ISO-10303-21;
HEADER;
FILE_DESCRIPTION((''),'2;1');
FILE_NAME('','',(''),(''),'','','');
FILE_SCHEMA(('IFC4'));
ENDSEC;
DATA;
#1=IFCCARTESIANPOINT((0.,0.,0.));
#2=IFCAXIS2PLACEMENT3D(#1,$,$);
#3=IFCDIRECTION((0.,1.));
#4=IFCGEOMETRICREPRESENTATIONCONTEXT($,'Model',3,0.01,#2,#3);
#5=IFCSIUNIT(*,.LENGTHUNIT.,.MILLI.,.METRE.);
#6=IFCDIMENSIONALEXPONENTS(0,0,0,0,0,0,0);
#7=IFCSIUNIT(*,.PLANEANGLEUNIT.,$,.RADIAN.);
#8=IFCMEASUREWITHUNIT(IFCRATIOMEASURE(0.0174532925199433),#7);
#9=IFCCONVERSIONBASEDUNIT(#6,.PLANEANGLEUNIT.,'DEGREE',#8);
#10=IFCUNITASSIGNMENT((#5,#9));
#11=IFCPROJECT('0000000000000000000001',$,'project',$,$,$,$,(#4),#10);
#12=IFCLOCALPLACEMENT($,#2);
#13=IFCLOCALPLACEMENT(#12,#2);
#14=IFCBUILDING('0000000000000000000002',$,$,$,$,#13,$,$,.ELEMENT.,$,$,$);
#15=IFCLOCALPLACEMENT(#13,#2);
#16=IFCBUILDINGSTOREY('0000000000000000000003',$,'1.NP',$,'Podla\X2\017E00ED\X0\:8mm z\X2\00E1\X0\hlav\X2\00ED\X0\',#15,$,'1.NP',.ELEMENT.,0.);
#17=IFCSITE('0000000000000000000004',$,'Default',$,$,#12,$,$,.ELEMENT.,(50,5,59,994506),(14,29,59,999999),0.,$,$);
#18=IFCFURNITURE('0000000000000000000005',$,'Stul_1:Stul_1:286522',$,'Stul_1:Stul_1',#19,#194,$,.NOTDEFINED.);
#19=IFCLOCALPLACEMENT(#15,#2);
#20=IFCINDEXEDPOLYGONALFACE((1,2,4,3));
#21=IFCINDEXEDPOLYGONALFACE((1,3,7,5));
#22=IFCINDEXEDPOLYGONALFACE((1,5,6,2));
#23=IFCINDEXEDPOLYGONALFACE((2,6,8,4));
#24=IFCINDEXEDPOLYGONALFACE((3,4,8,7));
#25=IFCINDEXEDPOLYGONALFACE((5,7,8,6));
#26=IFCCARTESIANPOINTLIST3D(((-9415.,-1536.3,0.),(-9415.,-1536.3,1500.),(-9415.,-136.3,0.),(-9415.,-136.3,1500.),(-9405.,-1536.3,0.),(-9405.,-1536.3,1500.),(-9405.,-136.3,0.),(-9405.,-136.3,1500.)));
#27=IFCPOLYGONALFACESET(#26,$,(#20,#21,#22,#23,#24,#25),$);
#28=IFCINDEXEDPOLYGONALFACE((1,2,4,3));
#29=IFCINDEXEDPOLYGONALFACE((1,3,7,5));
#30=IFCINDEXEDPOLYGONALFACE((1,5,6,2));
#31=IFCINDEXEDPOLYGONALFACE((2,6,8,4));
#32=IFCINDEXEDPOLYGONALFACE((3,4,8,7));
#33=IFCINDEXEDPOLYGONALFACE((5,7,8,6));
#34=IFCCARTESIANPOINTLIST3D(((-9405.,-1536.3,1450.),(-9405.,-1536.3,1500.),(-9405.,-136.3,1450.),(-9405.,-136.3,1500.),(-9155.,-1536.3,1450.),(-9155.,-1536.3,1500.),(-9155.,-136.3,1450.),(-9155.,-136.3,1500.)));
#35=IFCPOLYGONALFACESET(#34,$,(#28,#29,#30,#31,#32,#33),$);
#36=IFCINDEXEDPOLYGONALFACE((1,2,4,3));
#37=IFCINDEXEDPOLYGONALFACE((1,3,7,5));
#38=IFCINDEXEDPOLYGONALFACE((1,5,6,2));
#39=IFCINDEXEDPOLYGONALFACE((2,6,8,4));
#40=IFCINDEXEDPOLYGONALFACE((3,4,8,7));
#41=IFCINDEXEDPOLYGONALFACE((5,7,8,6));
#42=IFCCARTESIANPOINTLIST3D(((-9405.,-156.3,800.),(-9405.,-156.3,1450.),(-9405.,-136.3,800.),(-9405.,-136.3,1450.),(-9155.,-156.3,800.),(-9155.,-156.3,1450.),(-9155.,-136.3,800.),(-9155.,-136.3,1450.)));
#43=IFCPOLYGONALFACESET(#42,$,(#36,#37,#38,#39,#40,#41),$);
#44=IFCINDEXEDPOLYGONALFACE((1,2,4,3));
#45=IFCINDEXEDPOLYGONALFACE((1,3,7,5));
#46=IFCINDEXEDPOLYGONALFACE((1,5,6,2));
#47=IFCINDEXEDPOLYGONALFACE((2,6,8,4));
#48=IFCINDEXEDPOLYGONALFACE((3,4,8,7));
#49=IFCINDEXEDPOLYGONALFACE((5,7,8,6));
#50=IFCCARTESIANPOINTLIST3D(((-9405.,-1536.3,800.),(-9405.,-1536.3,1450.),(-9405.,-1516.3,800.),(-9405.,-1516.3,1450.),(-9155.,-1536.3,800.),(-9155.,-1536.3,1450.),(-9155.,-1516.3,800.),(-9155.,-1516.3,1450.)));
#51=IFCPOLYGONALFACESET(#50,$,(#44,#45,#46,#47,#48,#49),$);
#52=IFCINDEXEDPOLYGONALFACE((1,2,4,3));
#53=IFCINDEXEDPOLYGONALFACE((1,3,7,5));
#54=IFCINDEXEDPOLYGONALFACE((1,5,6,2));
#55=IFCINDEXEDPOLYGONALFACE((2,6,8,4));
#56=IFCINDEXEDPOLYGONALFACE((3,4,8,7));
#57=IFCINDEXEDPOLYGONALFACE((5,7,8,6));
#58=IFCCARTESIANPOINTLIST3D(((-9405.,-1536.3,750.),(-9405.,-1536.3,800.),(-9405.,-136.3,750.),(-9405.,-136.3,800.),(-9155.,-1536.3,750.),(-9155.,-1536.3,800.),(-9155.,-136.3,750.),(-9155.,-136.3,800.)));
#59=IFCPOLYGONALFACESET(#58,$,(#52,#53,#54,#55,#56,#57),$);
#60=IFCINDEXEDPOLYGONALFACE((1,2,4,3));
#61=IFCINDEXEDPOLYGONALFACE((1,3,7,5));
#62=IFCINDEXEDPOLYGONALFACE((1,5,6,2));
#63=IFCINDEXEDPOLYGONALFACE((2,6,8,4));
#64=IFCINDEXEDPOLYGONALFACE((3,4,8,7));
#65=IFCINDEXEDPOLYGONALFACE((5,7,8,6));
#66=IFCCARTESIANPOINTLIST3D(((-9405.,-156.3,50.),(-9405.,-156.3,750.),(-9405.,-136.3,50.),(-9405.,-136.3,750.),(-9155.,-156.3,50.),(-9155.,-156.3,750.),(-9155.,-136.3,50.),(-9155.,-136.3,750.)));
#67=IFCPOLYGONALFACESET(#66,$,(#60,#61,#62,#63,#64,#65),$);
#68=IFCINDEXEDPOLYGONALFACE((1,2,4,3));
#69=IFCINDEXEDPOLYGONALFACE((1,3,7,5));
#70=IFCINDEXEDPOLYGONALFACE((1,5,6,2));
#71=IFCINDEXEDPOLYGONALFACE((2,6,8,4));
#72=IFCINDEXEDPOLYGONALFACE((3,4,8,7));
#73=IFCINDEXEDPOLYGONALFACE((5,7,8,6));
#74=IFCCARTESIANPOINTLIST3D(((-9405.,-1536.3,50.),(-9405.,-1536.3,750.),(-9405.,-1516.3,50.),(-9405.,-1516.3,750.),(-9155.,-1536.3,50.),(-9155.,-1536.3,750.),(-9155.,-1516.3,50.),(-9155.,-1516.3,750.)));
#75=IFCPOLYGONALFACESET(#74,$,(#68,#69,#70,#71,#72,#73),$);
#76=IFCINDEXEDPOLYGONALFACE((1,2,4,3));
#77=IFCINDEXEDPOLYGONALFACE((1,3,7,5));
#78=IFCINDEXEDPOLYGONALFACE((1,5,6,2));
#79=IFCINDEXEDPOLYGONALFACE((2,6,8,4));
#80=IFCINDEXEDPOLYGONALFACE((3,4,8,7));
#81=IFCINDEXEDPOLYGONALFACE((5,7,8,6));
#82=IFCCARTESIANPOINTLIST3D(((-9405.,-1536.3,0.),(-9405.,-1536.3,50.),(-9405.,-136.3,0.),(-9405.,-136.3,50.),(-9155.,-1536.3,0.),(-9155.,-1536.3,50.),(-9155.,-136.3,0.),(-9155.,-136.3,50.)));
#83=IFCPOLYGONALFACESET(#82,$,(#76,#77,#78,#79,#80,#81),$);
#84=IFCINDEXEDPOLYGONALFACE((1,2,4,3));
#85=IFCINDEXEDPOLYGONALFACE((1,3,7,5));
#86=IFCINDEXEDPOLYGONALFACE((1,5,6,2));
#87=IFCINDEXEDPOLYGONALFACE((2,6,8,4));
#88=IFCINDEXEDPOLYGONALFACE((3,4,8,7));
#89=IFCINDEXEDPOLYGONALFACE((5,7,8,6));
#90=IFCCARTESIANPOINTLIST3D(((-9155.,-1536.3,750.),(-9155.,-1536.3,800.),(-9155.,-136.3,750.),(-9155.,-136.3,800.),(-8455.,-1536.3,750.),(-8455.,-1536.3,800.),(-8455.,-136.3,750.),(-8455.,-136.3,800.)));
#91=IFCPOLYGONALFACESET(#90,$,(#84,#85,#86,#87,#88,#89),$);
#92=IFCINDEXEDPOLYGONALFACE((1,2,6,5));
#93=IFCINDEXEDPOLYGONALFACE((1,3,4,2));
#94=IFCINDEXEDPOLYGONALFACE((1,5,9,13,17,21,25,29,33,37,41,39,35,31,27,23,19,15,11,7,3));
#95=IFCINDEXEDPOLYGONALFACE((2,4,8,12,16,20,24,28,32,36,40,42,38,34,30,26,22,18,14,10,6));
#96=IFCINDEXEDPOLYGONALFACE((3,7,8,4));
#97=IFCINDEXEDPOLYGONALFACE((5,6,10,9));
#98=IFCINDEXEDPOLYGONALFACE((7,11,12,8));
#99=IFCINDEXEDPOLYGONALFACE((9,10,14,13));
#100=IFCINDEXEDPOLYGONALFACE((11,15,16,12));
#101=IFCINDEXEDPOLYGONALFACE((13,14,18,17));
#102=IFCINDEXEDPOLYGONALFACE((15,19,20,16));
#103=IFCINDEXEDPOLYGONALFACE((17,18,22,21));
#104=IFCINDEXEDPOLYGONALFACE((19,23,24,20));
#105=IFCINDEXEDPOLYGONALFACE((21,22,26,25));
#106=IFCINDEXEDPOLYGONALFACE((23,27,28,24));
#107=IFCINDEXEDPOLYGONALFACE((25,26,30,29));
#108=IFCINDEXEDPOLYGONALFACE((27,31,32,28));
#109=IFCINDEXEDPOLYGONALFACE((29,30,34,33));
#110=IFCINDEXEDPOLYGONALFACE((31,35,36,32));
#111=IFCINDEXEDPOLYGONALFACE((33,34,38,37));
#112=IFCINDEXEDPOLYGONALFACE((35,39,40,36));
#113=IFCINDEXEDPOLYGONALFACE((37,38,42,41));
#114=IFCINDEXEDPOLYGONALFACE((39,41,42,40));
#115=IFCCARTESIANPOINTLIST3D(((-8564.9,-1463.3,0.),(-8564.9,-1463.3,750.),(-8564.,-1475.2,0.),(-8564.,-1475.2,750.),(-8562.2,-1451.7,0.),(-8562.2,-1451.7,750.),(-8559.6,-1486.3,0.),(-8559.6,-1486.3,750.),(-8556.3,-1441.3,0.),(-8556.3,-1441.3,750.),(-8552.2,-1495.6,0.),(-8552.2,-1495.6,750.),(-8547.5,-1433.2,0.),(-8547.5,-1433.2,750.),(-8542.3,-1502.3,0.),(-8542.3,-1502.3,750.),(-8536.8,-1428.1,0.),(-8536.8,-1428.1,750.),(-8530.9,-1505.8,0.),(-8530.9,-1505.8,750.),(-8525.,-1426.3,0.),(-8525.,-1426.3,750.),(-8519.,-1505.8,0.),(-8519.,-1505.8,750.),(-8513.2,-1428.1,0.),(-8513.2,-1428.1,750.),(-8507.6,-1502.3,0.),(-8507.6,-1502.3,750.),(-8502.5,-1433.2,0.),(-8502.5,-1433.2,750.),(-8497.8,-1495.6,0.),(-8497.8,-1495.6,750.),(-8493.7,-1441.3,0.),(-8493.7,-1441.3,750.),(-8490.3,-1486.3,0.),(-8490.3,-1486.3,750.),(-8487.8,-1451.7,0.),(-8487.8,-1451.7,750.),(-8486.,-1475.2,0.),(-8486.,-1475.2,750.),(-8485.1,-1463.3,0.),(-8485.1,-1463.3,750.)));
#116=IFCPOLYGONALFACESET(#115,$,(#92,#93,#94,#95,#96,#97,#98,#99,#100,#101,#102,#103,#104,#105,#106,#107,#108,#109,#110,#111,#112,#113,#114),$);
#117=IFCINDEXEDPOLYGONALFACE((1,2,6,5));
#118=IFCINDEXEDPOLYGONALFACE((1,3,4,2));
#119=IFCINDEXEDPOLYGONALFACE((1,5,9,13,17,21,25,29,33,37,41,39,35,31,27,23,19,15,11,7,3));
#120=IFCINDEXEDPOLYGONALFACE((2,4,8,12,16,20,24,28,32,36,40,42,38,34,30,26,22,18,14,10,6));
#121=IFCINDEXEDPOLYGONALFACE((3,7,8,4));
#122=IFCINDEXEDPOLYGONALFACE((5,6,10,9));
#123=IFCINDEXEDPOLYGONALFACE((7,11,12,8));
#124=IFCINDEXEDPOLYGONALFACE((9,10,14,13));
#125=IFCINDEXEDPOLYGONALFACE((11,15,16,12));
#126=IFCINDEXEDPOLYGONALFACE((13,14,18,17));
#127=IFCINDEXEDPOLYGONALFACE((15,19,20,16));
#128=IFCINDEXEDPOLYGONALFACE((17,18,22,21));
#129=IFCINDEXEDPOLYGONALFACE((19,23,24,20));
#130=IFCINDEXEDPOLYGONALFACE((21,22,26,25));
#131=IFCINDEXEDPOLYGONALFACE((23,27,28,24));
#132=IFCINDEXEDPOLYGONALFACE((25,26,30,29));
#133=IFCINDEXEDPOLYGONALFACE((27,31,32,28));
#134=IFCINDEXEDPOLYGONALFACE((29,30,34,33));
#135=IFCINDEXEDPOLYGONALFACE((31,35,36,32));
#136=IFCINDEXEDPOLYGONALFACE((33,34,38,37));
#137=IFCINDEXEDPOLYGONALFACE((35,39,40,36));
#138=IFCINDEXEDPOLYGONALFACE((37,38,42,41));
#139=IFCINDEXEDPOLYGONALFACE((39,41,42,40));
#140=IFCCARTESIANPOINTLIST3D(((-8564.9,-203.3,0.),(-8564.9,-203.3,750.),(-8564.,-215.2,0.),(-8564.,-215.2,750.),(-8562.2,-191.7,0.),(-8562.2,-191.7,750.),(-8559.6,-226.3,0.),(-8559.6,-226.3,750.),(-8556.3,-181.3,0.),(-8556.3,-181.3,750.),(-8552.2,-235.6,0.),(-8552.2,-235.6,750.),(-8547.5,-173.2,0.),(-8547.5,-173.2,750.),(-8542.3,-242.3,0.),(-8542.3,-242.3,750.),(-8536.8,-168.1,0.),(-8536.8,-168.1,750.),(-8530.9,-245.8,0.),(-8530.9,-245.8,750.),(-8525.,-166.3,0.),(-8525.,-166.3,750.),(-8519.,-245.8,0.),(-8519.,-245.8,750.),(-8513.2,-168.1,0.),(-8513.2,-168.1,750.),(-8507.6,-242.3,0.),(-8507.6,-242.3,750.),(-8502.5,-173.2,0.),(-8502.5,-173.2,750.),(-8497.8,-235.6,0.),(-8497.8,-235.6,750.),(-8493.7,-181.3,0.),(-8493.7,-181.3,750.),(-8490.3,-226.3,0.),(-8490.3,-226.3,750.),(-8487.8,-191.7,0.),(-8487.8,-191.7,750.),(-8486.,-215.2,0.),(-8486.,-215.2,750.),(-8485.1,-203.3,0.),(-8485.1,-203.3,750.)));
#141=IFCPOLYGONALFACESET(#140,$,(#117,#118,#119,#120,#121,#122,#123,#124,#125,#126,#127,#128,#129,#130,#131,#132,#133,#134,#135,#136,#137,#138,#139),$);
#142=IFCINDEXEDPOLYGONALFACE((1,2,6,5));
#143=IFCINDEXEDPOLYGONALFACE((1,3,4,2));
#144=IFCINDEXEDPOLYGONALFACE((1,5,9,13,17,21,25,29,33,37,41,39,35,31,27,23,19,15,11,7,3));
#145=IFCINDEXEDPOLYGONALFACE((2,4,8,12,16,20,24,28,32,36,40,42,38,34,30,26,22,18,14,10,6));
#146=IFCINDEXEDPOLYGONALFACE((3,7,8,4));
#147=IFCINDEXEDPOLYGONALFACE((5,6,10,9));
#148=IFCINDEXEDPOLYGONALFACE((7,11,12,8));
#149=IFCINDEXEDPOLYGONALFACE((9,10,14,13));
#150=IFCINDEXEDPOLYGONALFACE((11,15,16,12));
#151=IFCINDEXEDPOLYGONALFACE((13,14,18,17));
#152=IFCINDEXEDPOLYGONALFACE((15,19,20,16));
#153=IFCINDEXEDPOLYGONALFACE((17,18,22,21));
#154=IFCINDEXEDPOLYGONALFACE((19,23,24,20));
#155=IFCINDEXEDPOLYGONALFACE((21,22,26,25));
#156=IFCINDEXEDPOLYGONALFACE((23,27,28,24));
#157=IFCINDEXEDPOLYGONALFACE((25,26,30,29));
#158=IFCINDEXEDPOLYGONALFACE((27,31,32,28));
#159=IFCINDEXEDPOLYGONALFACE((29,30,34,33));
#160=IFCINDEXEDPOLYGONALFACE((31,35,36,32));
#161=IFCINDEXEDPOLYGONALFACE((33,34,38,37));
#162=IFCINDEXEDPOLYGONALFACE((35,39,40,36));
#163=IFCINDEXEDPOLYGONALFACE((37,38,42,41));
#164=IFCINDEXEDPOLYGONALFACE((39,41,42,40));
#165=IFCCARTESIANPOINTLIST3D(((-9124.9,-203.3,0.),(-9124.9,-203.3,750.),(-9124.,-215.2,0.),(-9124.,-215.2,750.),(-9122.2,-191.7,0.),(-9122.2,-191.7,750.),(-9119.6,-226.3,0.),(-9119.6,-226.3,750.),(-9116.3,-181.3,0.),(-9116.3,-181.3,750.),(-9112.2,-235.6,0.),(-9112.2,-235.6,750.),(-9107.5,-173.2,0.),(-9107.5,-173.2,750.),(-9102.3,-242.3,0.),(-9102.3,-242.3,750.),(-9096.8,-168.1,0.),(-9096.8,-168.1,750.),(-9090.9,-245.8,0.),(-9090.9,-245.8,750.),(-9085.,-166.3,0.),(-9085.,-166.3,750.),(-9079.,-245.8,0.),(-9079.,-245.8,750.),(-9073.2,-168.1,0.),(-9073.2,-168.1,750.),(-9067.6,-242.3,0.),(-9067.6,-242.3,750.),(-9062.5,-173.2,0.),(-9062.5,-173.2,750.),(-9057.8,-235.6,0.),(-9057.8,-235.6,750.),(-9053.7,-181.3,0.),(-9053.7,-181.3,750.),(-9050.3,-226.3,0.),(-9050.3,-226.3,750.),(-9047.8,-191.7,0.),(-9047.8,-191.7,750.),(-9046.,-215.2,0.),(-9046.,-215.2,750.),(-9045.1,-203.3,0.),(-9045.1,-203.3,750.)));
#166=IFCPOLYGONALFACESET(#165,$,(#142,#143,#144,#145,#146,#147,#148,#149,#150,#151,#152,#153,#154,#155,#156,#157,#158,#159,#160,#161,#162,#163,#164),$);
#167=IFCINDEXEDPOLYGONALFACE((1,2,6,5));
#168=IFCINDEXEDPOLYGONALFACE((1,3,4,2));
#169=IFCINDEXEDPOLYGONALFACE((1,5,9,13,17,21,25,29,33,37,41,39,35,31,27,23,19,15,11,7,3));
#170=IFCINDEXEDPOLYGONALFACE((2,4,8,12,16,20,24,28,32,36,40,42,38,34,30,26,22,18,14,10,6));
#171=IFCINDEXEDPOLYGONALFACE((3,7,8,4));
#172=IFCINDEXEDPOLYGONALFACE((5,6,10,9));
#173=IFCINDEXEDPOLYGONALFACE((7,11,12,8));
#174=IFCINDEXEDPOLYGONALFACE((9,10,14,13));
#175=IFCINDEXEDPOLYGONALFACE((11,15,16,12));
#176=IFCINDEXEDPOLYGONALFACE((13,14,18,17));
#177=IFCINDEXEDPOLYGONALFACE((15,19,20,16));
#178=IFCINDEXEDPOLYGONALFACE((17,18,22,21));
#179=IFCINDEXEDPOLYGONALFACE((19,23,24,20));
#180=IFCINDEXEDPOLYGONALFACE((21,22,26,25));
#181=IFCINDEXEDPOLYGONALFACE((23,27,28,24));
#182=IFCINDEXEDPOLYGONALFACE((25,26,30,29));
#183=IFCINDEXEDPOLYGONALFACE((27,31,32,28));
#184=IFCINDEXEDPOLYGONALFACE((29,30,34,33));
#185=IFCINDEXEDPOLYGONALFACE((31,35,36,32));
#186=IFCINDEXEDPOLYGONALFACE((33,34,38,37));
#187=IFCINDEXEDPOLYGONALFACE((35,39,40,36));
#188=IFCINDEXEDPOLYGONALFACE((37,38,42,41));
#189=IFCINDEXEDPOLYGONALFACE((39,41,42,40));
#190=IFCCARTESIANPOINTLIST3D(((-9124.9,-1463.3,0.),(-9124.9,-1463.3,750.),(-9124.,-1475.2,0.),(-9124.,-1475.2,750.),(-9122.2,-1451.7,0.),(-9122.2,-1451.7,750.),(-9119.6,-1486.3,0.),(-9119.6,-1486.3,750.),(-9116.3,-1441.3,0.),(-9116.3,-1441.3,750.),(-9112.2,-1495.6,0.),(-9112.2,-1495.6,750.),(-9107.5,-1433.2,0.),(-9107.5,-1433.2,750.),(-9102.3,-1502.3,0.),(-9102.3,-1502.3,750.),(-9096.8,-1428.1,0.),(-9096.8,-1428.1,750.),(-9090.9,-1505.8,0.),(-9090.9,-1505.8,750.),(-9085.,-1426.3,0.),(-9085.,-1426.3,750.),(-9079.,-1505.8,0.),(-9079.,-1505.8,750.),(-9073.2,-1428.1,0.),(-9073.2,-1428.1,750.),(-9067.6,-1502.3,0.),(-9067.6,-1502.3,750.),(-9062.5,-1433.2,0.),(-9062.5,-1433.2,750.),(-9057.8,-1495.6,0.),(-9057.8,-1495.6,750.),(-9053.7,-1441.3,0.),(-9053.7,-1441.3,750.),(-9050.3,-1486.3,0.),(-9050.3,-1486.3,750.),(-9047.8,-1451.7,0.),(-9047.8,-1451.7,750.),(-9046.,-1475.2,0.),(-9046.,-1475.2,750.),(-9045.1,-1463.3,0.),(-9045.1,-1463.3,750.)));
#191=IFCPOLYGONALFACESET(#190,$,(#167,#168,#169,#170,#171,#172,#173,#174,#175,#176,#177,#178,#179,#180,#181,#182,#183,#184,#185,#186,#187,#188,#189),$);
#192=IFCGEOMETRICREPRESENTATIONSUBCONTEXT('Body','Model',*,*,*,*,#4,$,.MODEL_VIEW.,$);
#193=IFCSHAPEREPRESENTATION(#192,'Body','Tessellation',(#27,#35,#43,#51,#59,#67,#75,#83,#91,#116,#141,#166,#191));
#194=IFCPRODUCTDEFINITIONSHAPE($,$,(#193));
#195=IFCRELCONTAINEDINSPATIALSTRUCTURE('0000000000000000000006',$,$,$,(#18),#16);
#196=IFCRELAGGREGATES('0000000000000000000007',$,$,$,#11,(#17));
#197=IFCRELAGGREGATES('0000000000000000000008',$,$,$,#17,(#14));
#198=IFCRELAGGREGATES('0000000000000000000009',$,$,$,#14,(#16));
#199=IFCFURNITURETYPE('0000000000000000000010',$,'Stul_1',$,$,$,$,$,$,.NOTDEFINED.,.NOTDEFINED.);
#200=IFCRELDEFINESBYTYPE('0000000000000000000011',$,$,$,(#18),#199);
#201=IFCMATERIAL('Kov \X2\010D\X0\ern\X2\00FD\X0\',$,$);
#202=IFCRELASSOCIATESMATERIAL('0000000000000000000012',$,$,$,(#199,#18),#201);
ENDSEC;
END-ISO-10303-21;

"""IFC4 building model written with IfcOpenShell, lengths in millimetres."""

from ifc_helpers import new_model, entity, si_unit, converted_unit, direction, frame, frame_2d, origin, origin_2d_with_axis, place, context, subcontext, project, spatial, rectangle, circle, extrude, source, transform, mapped, material, type_object, type_shapes, element, save


model = new_model("IFC4")

# Units and contexts
model_context = context("Model", 3, precision=0.01, world=origin(), true_north=direction((0.0, 1.0)))
body_context = subcontext(model_context, "Body", "Model", "MODEL_VIEW")
ifc_project = project(units=[si_unit("LENGTHUNIT", "METRE", prefix="MILLI"), converted_unit("PLANEANGLEUNIT", "DEGREE", entity("IfcRatioMeasure", 0.0174532925199433), si_unit("PLANEANGLEUNIT", "RADIAN"), dimensions=[0, 0, 0, 0, 0, 0, 0])], contexts=[model_context])

# Site, building, storey
site_placement = place(None, origin())
site = spatial("IfcSite", under=ifc_project, at=site_placement, Name="Default", CompositionType="ELEMENT", RefLatitude=(50, 5, 59, 994506), RefLongitude=(14, 29, 59, 999999), RefElevation=0.0)
building_placement = place(site_placement, origin())
building = spatial("IfcBuilding", under=site, at=building_placement, CompositionType="ELEMENT")
storey_placement = place(building_placement, origin())
storey = spatial("IfcBuildingStorey", under=building, at=storey_placement, Name="1.NP", ObjectType="Podlaží:8mm záhlaví", LongName="1.NP", CompositionType="ELEMENT", Elevation=0.0)

# Furniture
ifc_material_1 = material(Name="Kov černý")
furniture_type = type_object("IfcFurnitureType", Name="Stul_1", AssemblyPlace="NOTDEFINED", PredefinedType="NOTDEFINED", material=ifc_material_1)
shared_shape_1 = source(origin(), body_context, "Body", "SweptSolid", [
    extrude(rectangle(XDim=1400.0, YDim=10.0, at=origin_2d_with_axis()), frame((0.0, 605.0, 0.0), z_axis=(0.0, 0.0, 1.0), x_axis=(-1.0, 0.0, 0.0)), (0.0, 0.0, 1.0), 1500.0),
    extrude(rectangle(XDim=1400.0, YDim=250.0, at=frame_2d((0.0, 0.0), x_axis=(1.0, 0.0))), frame((0.0, 475.0, 1450.0), z_axis=(0.0, 0.0, 1.0), x_axis=(-1.0, 0.0, 0.0)), (0.0, 0.0, 1.0), 50.0),
    extrude(rectangle(XDim=20.0, YDim=250.0, at=origin_2d_with_axis()), frame((690.0, 475.0, 800.0), z_axis=(0.0, 0.0, 1.0), x_axis=(-1.0, 0.0, 0.0)), (0.0, 0.0, 1.0), 650.0),
    extrude(rectangle(XDim=20.0, YDim=250.0, at=frame_2d((0.0, 0.0), x_axis=(1.0, 0.0))), frame((-690.0, 475.0, 800.0), z_axis=(0.0, 0.0, 1.0), x_axis=(-1.0, 0.0, 0.0)), (0.0, 0.0, 1.0), 650.0),
    extrude(rectangle(XDim=1400.0, YDim=250.0, at=origin_2d_with_axis()), frame((0.0, 475.0, 750.0), z_axis=(0.0, 0.0, 1.0), x_axis=(-1.0, 0.0, 0.0)), (0.0, 0.0, 1.0), 50.0),
    extrude(rectangle(XDim=20.0, YDim=250.0, at=origin_2d_with_axis()), frame((690.0, 475.0, 50.0), z_axis=(0.0, 0.0, 1.0), x_axis=(-1.0, 0.0, 0.0)), (0.0, 0.0, 1.0), 700.0),
    extrude(rectangle(XDim=20.0, YDim=250.0, at=frame_2d((0.0, 0.0), x_axis=(1.0, 0.0))), frame((-690.0, 475.0, 50.0), z_axis=(0.0, 0.0, 1.0), x_axis=(-1.0, 0.0, 0.0)), (0.0, 0.0, 1.0), 700.0),
    extrude(rectangle(XDim=1400.0, YDim=250.0, at=origin_2d_with_axis()), frame((0.0, 475.0, 0.0), z_axis=(0.0, 0.0, 1.0), x_axis=(-1.0, 0.0, 0.0)), (0.0, 0.0, 1.0), 50.0),
    extrude(rectangle(XDim=1400.0, YDim=700.0, at=origin_2d_with_axis()), frame((0.0, 0.0, 750.0), z_axis=(0.0, 0.0, 1.0), x_axis=(-1.0, 0.0, 0.0)), (0.0, 0.0, 1.0), 50.0),
    extrude(circle(Radius=40.0, at=frame_2d((0.0, 0.0), x_axis=(1.0, 0.0))), frame((-630.0, -280.0, 0.0)), (0.0, 0.0, 1.0), 750.0),
    extrude(circle(Radius=40.0, at=frame_2d((0.0, 0.0), x_axis=(1.0, 0.0))), frame((630.0, -280.0, 0.0)), (0.0, 0.0, 1.0), 750.0),
    extrude(circle(Radius=40.0, at=frame_2d((0.0, 0.0), x_axis=(1.0, 0.0))), frame((630.0, 280.0, 0.0)), (0.0, 0.0, 1.0), 750.0),
    extrude(circle(Radius=40.0, at=frame_2d((0.0, 0.0), x_axis=(1.0, 0.0))), frame((-630.0, 280.0, 0.0)), (0.0, 0.0, 1.0), 750.0),
])
type_shapes(furniture_type, [shared_shape_1])
for number, where, z_axis, x_axis, name in (
    (1, (-8805.0, -836.3, 0.0), (0.0, 0.0, 1.0), (0.0, 1.0, 0.0), "Stul_1:Stul_1:286522"),
):
    element("IfcFurniture", number, at=place(storey_placement, frame(where, z_axis=z_axis, x_axis=x_axis)), inside=storey, type_object=furniture_type, material=ifc_material_1, Name=name, ObjectType="Stul_1:Stul_1", PredefinedType="NOTDEFINED", context=body_context, shape_type="MappedRepresentation", body=[
        mapped(shared_shape_1, transform((0.0, 0.0, 0.0), scale=1.0)),
    ])

save(model, "model.ifc")
